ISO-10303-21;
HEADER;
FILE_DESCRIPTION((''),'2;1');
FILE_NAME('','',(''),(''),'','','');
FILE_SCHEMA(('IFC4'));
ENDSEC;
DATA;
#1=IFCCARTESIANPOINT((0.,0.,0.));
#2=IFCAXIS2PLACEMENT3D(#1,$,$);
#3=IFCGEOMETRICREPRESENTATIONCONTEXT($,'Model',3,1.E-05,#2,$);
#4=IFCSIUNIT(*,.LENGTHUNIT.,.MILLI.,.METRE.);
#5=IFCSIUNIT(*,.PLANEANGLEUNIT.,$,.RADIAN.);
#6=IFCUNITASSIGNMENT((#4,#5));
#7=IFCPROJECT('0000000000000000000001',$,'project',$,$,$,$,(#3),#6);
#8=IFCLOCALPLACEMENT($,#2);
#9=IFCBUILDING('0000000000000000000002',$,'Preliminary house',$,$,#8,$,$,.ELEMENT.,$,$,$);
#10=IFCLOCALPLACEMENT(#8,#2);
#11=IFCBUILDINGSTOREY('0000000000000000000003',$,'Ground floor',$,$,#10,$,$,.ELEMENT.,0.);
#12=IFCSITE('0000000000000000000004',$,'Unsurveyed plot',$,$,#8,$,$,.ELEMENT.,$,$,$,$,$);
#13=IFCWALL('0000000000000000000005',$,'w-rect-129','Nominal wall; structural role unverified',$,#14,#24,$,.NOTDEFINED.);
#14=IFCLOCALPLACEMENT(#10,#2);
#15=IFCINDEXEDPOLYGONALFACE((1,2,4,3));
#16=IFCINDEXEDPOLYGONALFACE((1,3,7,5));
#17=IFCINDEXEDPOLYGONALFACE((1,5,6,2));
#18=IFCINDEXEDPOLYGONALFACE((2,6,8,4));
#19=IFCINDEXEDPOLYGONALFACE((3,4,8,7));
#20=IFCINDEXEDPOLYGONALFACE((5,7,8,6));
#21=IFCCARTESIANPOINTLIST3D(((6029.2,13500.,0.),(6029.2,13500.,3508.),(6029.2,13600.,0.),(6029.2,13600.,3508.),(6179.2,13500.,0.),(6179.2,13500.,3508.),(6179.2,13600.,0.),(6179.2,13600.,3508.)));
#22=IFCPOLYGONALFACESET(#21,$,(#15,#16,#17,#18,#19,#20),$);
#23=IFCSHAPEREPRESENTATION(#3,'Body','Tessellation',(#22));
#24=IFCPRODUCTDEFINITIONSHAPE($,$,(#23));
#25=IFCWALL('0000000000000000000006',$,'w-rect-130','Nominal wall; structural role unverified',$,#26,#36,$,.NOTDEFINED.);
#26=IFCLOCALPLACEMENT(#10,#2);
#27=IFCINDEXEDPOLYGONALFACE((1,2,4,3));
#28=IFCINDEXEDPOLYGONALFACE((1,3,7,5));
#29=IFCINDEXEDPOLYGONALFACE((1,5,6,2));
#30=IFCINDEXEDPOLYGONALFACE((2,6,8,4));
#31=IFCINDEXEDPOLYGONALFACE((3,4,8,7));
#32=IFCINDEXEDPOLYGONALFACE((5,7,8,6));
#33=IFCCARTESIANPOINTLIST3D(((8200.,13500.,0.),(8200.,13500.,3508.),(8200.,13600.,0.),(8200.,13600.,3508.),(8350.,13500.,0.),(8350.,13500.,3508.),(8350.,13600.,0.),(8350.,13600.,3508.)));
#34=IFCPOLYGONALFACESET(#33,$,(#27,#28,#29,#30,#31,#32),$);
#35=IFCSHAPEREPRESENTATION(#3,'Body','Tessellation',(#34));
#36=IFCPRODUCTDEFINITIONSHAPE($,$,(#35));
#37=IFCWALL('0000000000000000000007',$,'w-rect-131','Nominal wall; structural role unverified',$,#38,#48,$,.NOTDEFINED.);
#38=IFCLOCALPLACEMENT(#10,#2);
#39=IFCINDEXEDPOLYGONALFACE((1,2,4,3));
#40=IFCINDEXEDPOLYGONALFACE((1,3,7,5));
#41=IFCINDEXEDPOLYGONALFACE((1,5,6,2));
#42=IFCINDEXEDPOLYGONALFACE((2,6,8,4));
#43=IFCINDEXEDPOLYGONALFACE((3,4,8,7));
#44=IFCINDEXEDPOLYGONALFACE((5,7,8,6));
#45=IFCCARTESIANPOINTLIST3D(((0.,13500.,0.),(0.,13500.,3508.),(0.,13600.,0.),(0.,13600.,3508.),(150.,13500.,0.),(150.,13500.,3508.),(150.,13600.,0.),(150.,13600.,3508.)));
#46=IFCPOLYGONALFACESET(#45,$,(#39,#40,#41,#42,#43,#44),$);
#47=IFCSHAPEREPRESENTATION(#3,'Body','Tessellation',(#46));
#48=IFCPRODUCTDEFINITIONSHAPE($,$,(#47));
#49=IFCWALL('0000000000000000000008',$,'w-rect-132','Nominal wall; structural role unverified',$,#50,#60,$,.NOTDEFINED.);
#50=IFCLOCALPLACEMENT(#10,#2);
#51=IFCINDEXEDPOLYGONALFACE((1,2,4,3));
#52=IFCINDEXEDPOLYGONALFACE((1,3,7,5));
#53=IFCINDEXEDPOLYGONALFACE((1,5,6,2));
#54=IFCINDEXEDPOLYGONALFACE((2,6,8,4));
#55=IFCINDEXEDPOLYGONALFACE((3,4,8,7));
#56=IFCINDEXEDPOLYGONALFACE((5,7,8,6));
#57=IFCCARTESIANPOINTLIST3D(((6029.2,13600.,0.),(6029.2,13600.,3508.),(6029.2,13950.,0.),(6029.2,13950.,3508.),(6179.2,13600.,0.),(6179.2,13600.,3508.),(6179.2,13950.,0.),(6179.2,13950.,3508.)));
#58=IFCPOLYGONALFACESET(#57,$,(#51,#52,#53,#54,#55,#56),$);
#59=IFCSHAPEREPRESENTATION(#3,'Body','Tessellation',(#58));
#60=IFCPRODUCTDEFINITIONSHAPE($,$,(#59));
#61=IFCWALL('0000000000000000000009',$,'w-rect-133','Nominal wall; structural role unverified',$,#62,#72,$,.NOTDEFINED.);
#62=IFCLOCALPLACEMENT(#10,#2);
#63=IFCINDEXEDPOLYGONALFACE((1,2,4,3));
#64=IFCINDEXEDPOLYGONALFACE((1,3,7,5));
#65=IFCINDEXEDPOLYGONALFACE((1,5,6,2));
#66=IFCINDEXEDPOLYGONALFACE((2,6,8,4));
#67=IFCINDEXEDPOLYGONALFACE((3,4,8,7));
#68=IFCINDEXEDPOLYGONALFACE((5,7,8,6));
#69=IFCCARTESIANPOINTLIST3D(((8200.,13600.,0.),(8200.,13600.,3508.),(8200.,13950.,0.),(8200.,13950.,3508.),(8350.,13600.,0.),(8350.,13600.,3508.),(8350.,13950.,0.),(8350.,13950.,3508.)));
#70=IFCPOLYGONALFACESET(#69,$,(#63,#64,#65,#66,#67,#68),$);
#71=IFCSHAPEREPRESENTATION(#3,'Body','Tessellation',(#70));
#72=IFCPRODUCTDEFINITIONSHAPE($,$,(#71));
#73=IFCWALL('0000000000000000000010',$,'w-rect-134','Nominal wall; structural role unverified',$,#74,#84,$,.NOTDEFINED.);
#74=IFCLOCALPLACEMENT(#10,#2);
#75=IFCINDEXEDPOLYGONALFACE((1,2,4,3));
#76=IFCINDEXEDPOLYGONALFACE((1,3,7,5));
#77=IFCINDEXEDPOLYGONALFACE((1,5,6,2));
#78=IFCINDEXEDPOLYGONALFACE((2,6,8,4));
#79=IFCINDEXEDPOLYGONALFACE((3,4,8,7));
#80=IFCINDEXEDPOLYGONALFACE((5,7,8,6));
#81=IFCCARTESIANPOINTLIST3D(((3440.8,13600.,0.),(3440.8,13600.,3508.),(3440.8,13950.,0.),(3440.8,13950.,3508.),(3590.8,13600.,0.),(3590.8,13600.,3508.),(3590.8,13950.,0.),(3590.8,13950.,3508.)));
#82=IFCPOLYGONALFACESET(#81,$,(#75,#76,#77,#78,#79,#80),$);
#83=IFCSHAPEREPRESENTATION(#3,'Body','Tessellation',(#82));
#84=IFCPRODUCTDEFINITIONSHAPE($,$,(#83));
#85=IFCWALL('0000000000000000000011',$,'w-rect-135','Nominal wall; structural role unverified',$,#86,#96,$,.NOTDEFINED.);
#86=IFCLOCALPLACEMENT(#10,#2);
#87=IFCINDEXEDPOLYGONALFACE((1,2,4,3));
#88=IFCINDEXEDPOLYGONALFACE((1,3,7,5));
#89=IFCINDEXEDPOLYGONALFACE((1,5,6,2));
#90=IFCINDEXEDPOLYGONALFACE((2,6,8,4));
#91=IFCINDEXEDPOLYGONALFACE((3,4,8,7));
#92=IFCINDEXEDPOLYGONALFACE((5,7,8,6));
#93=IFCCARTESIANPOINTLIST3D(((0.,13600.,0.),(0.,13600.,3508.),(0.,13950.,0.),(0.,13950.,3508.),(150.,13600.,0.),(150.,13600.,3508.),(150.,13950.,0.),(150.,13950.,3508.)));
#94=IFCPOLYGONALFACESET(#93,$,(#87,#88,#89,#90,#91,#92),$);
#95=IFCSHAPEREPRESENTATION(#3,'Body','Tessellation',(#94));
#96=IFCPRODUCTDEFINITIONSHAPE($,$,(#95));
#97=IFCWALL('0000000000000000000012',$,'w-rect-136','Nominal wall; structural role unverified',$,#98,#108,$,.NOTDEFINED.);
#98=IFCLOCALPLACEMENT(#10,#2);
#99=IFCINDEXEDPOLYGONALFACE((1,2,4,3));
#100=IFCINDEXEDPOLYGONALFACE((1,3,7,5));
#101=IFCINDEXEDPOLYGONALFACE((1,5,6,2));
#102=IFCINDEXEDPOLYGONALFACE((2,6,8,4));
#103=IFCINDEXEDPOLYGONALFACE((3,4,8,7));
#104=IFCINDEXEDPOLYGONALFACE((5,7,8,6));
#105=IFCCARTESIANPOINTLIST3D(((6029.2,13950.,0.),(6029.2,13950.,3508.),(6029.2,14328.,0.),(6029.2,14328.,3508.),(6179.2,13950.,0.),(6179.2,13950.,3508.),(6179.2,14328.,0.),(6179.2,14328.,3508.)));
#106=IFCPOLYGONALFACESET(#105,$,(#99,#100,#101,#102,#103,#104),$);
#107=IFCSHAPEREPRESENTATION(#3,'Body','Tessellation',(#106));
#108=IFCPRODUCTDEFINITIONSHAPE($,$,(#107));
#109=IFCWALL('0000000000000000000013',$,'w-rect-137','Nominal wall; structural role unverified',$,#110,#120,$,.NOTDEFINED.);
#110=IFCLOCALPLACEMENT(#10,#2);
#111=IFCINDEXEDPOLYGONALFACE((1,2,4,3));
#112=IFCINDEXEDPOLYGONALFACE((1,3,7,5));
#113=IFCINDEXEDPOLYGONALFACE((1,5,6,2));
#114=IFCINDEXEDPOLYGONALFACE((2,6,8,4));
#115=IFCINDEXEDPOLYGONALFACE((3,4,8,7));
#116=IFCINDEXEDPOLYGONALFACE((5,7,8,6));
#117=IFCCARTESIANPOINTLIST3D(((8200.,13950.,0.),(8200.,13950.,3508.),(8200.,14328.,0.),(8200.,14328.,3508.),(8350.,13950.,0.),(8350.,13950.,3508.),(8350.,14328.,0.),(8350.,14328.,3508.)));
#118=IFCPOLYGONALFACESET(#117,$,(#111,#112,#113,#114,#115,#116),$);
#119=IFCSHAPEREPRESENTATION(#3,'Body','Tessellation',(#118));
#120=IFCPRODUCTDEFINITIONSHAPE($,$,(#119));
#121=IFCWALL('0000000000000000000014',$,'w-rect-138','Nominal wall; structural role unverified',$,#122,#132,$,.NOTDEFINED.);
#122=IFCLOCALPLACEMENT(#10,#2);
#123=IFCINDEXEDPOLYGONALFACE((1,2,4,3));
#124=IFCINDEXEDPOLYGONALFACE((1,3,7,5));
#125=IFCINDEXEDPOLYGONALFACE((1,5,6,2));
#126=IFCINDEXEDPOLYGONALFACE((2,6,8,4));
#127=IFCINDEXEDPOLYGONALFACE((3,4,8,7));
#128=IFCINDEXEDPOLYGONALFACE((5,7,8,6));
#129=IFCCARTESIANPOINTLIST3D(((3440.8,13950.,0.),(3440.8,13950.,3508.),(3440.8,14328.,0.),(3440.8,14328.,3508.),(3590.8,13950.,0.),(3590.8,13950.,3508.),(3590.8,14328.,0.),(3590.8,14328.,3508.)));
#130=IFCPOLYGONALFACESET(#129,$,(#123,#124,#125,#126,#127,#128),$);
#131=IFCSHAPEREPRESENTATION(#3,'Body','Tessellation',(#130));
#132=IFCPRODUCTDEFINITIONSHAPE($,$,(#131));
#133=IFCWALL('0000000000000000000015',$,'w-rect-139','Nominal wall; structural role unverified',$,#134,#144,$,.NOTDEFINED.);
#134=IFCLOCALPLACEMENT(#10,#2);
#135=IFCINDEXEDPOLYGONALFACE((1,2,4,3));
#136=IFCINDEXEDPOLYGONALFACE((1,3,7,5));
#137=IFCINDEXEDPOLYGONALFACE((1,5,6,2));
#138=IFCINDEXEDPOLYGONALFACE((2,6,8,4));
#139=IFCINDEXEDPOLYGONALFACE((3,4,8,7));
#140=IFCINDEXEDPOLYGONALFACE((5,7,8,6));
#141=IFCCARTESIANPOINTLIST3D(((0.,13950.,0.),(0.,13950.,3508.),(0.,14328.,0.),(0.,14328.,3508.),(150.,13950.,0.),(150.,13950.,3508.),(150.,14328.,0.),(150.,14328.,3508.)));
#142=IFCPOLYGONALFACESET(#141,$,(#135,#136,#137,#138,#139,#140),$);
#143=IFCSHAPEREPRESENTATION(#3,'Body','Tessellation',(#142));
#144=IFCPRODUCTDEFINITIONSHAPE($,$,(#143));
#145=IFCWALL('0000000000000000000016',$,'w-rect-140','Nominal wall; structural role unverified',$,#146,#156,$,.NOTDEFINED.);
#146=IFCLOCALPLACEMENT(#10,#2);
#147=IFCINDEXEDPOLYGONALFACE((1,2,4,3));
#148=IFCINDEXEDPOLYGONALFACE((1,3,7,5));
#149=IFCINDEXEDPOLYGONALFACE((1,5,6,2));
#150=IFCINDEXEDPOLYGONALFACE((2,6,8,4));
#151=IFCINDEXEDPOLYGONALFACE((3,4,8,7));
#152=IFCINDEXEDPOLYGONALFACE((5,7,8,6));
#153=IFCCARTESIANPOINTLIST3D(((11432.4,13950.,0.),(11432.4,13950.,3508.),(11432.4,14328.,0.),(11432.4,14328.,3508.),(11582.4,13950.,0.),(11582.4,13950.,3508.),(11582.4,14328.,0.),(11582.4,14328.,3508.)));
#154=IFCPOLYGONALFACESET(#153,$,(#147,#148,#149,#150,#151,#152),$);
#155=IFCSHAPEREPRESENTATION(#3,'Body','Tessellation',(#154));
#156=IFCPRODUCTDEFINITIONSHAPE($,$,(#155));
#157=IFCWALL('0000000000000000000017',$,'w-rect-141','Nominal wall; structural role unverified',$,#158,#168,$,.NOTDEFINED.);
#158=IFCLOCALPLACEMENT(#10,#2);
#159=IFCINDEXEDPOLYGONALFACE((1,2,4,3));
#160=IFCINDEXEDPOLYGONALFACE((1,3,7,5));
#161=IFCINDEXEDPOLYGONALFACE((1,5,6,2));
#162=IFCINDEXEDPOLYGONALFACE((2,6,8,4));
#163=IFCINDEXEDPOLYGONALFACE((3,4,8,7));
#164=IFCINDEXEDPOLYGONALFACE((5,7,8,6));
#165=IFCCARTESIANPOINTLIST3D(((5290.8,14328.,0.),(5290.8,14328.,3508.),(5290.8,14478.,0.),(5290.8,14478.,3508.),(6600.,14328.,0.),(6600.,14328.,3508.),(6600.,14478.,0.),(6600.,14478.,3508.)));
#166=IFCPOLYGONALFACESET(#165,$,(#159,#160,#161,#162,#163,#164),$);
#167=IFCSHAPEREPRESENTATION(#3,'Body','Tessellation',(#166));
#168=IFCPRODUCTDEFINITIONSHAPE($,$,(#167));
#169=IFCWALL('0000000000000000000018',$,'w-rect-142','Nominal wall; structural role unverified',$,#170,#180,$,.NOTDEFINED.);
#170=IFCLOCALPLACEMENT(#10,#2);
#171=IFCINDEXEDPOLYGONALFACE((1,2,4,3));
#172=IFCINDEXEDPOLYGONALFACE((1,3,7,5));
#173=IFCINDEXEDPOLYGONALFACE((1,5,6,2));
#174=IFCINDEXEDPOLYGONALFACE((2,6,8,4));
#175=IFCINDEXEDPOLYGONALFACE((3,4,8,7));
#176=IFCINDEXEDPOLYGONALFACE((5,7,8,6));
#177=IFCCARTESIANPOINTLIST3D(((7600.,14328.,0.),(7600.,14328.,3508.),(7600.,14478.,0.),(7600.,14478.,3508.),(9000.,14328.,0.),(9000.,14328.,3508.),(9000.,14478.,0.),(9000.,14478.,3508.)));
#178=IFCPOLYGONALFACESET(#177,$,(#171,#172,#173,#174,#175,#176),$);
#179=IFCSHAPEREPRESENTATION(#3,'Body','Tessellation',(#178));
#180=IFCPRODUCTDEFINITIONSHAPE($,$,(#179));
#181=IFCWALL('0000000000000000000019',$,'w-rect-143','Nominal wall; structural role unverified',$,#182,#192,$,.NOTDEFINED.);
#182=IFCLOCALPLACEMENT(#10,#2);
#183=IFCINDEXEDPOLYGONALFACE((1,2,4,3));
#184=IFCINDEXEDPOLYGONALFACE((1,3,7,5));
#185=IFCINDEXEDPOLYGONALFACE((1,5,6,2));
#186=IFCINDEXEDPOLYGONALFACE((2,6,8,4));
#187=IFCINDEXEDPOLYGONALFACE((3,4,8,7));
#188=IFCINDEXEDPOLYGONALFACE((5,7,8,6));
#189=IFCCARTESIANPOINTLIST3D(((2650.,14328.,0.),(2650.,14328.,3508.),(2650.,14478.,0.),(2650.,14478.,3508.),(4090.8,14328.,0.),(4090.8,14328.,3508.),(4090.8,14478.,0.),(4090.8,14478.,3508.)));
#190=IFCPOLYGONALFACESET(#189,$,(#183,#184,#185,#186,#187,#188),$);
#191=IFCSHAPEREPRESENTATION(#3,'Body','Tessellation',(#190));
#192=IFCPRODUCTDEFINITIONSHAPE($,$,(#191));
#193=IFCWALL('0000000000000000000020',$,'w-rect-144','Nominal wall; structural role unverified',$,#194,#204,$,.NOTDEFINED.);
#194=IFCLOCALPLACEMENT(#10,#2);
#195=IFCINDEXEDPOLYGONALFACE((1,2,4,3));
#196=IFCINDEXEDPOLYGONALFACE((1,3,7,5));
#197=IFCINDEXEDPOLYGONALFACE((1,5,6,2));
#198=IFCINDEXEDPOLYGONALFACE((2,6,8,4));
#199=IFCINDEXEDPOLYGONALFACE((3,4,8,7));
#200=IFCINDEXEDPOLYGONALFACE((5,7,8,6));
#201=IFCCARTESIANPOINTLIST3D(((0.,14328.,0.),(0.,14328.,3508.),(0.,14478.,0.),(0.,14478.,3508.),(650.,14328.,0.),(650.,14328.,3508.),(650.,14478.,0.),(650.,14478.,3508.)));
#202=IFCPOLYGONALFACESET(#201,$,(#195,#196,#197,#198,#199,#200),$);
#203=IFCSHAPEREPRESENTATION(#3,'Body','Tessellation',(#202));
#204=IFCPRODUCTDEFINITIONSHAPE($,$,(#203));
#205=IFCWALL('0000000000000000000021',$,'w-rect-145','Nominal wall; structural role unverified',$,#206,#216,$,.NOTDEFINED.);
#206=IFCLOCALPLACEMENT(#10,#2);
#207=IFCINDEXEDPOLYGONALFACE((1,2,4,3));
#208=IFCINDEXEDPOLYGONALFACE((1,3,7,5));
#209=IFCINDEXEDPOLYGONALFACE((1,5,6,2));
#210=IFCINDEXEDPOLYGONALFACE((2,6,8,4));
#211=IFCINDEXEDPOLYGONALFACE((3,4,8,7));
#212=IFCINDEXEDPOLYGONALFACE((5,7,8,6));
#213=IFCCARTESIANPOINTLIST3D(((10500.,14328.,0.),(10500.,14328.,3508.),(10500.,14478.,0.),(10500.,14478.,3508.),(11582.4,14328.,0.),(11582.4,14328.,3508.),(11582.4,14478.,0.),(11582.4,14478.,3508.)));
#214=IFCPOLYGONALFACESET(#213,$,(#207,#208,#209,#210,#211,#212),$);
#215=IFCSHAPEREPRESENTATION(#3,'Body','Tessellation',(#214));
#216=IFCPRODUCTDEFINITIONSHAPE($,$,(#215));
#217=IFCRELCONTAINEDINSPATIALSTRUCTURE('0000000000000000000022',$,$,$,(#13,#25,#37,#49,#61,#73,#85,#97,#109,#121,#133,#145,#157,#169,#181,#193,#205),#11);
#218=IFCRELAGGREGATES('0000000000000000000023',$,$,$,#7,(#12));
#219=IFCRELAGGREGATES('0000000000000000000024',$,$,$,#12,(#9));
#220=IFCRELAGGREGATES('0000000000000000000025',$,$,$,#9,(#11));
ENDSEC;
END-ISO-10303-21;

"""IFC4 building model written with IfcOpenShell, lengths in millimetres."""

from ifc_helpers import new_model, si_unit, origin, place, context, project, spatial, polyline, outline, extrude, element, save


model = new_model("IFC4")

# Units and contexts
model_context = context("Model", 3, precision=1e-05, world=origin())
ifc_project = project(units=[si_unit("LENGTHUNIT", "METRE", prefix="MILLI"), si_unit("PLANEANGLEUNIT", "RADIAN")], contexts=[model_context])

# Site, building, storey
placement_1 = place(None, origin())
site = spatial("IfcSite", under=ifc_project, at=placement_1, Name="Unsurveyed plot", CompositionType="ELEMENT")
building = spatial("IfcBuilding", under=site, at=placement_1, Name="Preliminary house", CompositionType="ELEMENT")
placement_2 = place(placement_1, origin())
storey = spatial("IfcBuildingStorey", under=building, at=placement_2, Name="Ground floor", CompositionType="ELEMENT", Elevation=0.0)

# Walls
element("IfcWall", 1, at=placement_2, inside=storey, Name="w-rect-129", Description="Nominal wall; structural role unverified", PredefinedType="NOTDEFINED", context=model_context, shape_type="SweptSolid", body=[
    extrude(outline(polyline([(6029.2, 13500.0), (6179.2, 13500.0), (6179.2, 13600.0), (6029.2, 13600.0), (6029.2, 13500.0)])), origin(), (0.0, 0.0, 1.0), 3508.0),
])
element("IfcWall", 2, at=placement_2, inside=storey, Name="w-rect-130", Description="Nominal wall; structural role unverified", PredefinedType="NOTDEFINED", context=model_context, shape_type="SweptSolid", body=[
    extrude(outline(polyline([(8200.0, 13500.0), (8350.0, 13500.0), (8350.0, 13600.0), (8200.0, 13600.0), (8200.0, 13500.0)])), origin(), (0.0, 0.0, 1.0), 3508.0),
])
element("IfcWall", 3, at=placement_2, inside=storey, Name="w-rect-131", Description="Nominal wall; structural role unverified", PredefinedType="NOTDEFINED", context=model_context, shape_type="SweptSolid", body=[
    extrude(outline(polyline([(0.0, 13500.0), (150.0, 13500.0), (150.0, 13600.0), (0.0, 13600.0), (0.0, 13500.0)])), origin(), (0.0, 0.0, 1.0), 3508.0),
])
element("IfcWall", 4, at=placement_2, inside=storey, Name="w-rect-132", Description="Nominal wall; structural role unverified", PredefinedType="NOTDEFINED", context=model_context, shape_type="SweptSolid", body=[
    extrude(outline(polyline([(6029.2, 13600.0), (6179.2, 13600.0), (6179.2, 13950.0), (6029.2, 13950.0), (6029.2, 13600.0)])), origin(), (0.0, 0.0, 1.0), 3508.0),
])
element("IfcWall", 5, at=placement_2, inside=storey, Name="w-rect-133", Description="Nominal wall; structural role unverified", PredefinedType="NOTDEFINED", context=model_context, shape_type="SweptSolid", body=[
    extrude(outline(polyline([(8200.0, 13600.0), (8350.0, 13600.0), (8350.0, 13950.0), (8200.0, 13950.0), (8200.0, 13600.0)])), origin(), (0.0, 0.0, 1.0), 3508.0),
])
element("IfcWall", 6, at=placement_2, inside=storey, Name="w-rect-134", Description="Nominal wall; structural role unverified", PredefinedType="NOTDEFINED", context=model_context, shape_type="SweptSolid", body=[
    extrude(outline(polyline([(3440.8, 13600.0), (3590.8, 13600.0), (3590.8, 13950.0), (3440.8, 13950.0), (3440.8, 13600.0)])), origin(), (0.0, 0.0, 1.0), 3508.0),
])
element("IfcWall", 7, at=placement_2, inside=storey, Name="w-rect-135", Description="Nominal wall; structural role unverified", PredefinedType="NOTDEFINED", context=model_context, shape_type="SweptSolid", body=[
    extrude(outline(polyline([(0.0, 13600.0), (150.0, 13600.0), (150.0, 13950.0), (0.0, 13950.0), (0.0, 13600.0)])), origin(), (0.0, 0.0, 1.0), 3508.0),
])
element("IfcWall", 8, at=placement_2, inside=storey, Name="w-rect-136", Description="Nominal wall; structural role unverified", PredefinedType="NOTDEFINED", context=model_context, shape_type="SweptSolid", body=[
    extrude(outline(polyline([(6029.2, 13950.0), (6179.2, 13950.0), (6179.2, 14328.0), (6029.2, 14328.0), (6029.2, 13950.0)])), origin(), (0.0, 0.0, 1.0), 3508.0),
])
element("IfcWall", 9, at=placement_2, inside=storey, Name="w-rect-137", Description="Nominal wall; structural role unverified", PredefinedType="NOTDEFINED", context=model_context, shape_type="SweptSolid", body=[
    extrude(outline(polyline([(8200.0, 13950.0), (8350.0, 13950.0), (8350.0, 14328.0), (8200.0, 14328.0), (8200.0, 13950.0)])), origin(), (0.0, 0.0, 1.0), 3508.0),
])
element("IfcWall", 10, at=placement_2, inside=storey, Name="w-rect-138", Description="Nominal wall; structural role unverified", PredefinedType="NOTDEFINED", context=model_context, shape_type="SweptSolid", body=[
    extrude(outline(polyline([(3440.8, 13950.0), (3590.8, 13950.0), (3590.8, 14328.0), (3440.8, 14328.0), (3440.8, 13950.0)])), origin(), (0.0, 0.0, 1.0), 3508.0),
])
element("IfcWall", 11, at=placement_2, inside=storey, Name="w-rect-139", Description="Nominal wall; structural role unverified", PredefinedType="NOTDEFINED", context=model_context, shape_type="SweptSolid", body=[
    extrude(outline(polyline([(0.0, 13950.0), (150.0, 13950.0), (150.0, 14328.0), (0.0, 14328.0), (0.0, 13950.0)])), origin(), (0.0, 0.0, 1.0), 3508.0),
])
element("IfcWall", 12, at=placement_2, inside=storey, Name="w-rect-140", Description="Nominal wall; structural role unverified", PredefinedType="NOTDEFINED", context=model_context, shape_type="SweptSolid", body=[
    extrude(outline(polyline([(11432.4, 13950.0), (11582.4, 13950.0), (11582.4, 14328.0), (11432.4, 14328.0), (11432.4, 13950.0)])), origin(), (0.0, 0.0, 1.0), 3508.0),
])
element("IfcWall", 13, at=placement_2, inside=storey, Name="w-rect-141", Description="Nominal wall; structural role unverified", PredefinedType="NOTDEFINED", context=model_context, shape_type="SweptSolid", body=[
    extrude(outline(polyline([(5290.8, 14328.0), (6600.0, 14328.0), (6600.0, 14478.0), (5290.8, 14478.0), (5290.8, 14328.0)])), origin(), (0.0, 0.0, 1.0), 3508.0),
])
element("IfcWall", 14, at=placement_2, inside=storey, Name="w-rect-142", Description="Nominal wall; structural role unverified", PredefinedType="NOTDEFINED", context=model_context, shape_type="SweptSolid", body=[
    extrude(outline(polyline([(7600.0, 14328.0), (9000.0, 14328.0), (9000.0, 14478.0), (7600.0, 14478.0), (7600.0, 14328.0)])), origin(), (0.0, 0.0, 1.0), 3508.0),
])
element("IfcWall", 15, at=placement_2, inside=storey, Name="w-rect-143", Description="Nominal wall; structural role unverified", PredefinedType="NOTDEFINED", context=model_context, shape_type="SweptSolid", body=[
    extrude(outline(polyline([(2650.0, 14328.0), (4090.8, 14328.0), (4090.8, 14478.0), (2650.0, 14478.0), (2650.0, 14328.0)])), origin(), (0.0, 0.0, 1.0), 3508.0),
])
element("IfcWall", 16, at=placement_2, inside=storey, Name="w-rect-144", Description="Nominal wall; structural role unverified", PredefinedType="NOTDEFINED", context=model_context, shape_type="SweptSolid", body=[
    extrude(outline(polyline([(0.0, 14328.0), (650.0, 14328.0), (650.0, 14478.0), (0.0, 14478.0), (0.0, 14328.0)])), origin(), (0.0, 0.0, 1.0), 3508.0),
])
element("IfcWall", 17, at=placement_2, inside=storey, Name="w-rect-145", Description="Nominal wall; structural role unverified", PredefinedType="NOTDEFINED", context=model_context, shape_type="SweptSolid", body=[
    extrude(outline(polyline([(10500.0, 14328.0), (11582.4, 14328.0), (11582.4, 14478.0), (10500.0, 14478.0), (10500.0, 14328.0)])), origin(), (0.0, 0.0, 1.0), 3508.0),
])

save(model, "model.ifc")
